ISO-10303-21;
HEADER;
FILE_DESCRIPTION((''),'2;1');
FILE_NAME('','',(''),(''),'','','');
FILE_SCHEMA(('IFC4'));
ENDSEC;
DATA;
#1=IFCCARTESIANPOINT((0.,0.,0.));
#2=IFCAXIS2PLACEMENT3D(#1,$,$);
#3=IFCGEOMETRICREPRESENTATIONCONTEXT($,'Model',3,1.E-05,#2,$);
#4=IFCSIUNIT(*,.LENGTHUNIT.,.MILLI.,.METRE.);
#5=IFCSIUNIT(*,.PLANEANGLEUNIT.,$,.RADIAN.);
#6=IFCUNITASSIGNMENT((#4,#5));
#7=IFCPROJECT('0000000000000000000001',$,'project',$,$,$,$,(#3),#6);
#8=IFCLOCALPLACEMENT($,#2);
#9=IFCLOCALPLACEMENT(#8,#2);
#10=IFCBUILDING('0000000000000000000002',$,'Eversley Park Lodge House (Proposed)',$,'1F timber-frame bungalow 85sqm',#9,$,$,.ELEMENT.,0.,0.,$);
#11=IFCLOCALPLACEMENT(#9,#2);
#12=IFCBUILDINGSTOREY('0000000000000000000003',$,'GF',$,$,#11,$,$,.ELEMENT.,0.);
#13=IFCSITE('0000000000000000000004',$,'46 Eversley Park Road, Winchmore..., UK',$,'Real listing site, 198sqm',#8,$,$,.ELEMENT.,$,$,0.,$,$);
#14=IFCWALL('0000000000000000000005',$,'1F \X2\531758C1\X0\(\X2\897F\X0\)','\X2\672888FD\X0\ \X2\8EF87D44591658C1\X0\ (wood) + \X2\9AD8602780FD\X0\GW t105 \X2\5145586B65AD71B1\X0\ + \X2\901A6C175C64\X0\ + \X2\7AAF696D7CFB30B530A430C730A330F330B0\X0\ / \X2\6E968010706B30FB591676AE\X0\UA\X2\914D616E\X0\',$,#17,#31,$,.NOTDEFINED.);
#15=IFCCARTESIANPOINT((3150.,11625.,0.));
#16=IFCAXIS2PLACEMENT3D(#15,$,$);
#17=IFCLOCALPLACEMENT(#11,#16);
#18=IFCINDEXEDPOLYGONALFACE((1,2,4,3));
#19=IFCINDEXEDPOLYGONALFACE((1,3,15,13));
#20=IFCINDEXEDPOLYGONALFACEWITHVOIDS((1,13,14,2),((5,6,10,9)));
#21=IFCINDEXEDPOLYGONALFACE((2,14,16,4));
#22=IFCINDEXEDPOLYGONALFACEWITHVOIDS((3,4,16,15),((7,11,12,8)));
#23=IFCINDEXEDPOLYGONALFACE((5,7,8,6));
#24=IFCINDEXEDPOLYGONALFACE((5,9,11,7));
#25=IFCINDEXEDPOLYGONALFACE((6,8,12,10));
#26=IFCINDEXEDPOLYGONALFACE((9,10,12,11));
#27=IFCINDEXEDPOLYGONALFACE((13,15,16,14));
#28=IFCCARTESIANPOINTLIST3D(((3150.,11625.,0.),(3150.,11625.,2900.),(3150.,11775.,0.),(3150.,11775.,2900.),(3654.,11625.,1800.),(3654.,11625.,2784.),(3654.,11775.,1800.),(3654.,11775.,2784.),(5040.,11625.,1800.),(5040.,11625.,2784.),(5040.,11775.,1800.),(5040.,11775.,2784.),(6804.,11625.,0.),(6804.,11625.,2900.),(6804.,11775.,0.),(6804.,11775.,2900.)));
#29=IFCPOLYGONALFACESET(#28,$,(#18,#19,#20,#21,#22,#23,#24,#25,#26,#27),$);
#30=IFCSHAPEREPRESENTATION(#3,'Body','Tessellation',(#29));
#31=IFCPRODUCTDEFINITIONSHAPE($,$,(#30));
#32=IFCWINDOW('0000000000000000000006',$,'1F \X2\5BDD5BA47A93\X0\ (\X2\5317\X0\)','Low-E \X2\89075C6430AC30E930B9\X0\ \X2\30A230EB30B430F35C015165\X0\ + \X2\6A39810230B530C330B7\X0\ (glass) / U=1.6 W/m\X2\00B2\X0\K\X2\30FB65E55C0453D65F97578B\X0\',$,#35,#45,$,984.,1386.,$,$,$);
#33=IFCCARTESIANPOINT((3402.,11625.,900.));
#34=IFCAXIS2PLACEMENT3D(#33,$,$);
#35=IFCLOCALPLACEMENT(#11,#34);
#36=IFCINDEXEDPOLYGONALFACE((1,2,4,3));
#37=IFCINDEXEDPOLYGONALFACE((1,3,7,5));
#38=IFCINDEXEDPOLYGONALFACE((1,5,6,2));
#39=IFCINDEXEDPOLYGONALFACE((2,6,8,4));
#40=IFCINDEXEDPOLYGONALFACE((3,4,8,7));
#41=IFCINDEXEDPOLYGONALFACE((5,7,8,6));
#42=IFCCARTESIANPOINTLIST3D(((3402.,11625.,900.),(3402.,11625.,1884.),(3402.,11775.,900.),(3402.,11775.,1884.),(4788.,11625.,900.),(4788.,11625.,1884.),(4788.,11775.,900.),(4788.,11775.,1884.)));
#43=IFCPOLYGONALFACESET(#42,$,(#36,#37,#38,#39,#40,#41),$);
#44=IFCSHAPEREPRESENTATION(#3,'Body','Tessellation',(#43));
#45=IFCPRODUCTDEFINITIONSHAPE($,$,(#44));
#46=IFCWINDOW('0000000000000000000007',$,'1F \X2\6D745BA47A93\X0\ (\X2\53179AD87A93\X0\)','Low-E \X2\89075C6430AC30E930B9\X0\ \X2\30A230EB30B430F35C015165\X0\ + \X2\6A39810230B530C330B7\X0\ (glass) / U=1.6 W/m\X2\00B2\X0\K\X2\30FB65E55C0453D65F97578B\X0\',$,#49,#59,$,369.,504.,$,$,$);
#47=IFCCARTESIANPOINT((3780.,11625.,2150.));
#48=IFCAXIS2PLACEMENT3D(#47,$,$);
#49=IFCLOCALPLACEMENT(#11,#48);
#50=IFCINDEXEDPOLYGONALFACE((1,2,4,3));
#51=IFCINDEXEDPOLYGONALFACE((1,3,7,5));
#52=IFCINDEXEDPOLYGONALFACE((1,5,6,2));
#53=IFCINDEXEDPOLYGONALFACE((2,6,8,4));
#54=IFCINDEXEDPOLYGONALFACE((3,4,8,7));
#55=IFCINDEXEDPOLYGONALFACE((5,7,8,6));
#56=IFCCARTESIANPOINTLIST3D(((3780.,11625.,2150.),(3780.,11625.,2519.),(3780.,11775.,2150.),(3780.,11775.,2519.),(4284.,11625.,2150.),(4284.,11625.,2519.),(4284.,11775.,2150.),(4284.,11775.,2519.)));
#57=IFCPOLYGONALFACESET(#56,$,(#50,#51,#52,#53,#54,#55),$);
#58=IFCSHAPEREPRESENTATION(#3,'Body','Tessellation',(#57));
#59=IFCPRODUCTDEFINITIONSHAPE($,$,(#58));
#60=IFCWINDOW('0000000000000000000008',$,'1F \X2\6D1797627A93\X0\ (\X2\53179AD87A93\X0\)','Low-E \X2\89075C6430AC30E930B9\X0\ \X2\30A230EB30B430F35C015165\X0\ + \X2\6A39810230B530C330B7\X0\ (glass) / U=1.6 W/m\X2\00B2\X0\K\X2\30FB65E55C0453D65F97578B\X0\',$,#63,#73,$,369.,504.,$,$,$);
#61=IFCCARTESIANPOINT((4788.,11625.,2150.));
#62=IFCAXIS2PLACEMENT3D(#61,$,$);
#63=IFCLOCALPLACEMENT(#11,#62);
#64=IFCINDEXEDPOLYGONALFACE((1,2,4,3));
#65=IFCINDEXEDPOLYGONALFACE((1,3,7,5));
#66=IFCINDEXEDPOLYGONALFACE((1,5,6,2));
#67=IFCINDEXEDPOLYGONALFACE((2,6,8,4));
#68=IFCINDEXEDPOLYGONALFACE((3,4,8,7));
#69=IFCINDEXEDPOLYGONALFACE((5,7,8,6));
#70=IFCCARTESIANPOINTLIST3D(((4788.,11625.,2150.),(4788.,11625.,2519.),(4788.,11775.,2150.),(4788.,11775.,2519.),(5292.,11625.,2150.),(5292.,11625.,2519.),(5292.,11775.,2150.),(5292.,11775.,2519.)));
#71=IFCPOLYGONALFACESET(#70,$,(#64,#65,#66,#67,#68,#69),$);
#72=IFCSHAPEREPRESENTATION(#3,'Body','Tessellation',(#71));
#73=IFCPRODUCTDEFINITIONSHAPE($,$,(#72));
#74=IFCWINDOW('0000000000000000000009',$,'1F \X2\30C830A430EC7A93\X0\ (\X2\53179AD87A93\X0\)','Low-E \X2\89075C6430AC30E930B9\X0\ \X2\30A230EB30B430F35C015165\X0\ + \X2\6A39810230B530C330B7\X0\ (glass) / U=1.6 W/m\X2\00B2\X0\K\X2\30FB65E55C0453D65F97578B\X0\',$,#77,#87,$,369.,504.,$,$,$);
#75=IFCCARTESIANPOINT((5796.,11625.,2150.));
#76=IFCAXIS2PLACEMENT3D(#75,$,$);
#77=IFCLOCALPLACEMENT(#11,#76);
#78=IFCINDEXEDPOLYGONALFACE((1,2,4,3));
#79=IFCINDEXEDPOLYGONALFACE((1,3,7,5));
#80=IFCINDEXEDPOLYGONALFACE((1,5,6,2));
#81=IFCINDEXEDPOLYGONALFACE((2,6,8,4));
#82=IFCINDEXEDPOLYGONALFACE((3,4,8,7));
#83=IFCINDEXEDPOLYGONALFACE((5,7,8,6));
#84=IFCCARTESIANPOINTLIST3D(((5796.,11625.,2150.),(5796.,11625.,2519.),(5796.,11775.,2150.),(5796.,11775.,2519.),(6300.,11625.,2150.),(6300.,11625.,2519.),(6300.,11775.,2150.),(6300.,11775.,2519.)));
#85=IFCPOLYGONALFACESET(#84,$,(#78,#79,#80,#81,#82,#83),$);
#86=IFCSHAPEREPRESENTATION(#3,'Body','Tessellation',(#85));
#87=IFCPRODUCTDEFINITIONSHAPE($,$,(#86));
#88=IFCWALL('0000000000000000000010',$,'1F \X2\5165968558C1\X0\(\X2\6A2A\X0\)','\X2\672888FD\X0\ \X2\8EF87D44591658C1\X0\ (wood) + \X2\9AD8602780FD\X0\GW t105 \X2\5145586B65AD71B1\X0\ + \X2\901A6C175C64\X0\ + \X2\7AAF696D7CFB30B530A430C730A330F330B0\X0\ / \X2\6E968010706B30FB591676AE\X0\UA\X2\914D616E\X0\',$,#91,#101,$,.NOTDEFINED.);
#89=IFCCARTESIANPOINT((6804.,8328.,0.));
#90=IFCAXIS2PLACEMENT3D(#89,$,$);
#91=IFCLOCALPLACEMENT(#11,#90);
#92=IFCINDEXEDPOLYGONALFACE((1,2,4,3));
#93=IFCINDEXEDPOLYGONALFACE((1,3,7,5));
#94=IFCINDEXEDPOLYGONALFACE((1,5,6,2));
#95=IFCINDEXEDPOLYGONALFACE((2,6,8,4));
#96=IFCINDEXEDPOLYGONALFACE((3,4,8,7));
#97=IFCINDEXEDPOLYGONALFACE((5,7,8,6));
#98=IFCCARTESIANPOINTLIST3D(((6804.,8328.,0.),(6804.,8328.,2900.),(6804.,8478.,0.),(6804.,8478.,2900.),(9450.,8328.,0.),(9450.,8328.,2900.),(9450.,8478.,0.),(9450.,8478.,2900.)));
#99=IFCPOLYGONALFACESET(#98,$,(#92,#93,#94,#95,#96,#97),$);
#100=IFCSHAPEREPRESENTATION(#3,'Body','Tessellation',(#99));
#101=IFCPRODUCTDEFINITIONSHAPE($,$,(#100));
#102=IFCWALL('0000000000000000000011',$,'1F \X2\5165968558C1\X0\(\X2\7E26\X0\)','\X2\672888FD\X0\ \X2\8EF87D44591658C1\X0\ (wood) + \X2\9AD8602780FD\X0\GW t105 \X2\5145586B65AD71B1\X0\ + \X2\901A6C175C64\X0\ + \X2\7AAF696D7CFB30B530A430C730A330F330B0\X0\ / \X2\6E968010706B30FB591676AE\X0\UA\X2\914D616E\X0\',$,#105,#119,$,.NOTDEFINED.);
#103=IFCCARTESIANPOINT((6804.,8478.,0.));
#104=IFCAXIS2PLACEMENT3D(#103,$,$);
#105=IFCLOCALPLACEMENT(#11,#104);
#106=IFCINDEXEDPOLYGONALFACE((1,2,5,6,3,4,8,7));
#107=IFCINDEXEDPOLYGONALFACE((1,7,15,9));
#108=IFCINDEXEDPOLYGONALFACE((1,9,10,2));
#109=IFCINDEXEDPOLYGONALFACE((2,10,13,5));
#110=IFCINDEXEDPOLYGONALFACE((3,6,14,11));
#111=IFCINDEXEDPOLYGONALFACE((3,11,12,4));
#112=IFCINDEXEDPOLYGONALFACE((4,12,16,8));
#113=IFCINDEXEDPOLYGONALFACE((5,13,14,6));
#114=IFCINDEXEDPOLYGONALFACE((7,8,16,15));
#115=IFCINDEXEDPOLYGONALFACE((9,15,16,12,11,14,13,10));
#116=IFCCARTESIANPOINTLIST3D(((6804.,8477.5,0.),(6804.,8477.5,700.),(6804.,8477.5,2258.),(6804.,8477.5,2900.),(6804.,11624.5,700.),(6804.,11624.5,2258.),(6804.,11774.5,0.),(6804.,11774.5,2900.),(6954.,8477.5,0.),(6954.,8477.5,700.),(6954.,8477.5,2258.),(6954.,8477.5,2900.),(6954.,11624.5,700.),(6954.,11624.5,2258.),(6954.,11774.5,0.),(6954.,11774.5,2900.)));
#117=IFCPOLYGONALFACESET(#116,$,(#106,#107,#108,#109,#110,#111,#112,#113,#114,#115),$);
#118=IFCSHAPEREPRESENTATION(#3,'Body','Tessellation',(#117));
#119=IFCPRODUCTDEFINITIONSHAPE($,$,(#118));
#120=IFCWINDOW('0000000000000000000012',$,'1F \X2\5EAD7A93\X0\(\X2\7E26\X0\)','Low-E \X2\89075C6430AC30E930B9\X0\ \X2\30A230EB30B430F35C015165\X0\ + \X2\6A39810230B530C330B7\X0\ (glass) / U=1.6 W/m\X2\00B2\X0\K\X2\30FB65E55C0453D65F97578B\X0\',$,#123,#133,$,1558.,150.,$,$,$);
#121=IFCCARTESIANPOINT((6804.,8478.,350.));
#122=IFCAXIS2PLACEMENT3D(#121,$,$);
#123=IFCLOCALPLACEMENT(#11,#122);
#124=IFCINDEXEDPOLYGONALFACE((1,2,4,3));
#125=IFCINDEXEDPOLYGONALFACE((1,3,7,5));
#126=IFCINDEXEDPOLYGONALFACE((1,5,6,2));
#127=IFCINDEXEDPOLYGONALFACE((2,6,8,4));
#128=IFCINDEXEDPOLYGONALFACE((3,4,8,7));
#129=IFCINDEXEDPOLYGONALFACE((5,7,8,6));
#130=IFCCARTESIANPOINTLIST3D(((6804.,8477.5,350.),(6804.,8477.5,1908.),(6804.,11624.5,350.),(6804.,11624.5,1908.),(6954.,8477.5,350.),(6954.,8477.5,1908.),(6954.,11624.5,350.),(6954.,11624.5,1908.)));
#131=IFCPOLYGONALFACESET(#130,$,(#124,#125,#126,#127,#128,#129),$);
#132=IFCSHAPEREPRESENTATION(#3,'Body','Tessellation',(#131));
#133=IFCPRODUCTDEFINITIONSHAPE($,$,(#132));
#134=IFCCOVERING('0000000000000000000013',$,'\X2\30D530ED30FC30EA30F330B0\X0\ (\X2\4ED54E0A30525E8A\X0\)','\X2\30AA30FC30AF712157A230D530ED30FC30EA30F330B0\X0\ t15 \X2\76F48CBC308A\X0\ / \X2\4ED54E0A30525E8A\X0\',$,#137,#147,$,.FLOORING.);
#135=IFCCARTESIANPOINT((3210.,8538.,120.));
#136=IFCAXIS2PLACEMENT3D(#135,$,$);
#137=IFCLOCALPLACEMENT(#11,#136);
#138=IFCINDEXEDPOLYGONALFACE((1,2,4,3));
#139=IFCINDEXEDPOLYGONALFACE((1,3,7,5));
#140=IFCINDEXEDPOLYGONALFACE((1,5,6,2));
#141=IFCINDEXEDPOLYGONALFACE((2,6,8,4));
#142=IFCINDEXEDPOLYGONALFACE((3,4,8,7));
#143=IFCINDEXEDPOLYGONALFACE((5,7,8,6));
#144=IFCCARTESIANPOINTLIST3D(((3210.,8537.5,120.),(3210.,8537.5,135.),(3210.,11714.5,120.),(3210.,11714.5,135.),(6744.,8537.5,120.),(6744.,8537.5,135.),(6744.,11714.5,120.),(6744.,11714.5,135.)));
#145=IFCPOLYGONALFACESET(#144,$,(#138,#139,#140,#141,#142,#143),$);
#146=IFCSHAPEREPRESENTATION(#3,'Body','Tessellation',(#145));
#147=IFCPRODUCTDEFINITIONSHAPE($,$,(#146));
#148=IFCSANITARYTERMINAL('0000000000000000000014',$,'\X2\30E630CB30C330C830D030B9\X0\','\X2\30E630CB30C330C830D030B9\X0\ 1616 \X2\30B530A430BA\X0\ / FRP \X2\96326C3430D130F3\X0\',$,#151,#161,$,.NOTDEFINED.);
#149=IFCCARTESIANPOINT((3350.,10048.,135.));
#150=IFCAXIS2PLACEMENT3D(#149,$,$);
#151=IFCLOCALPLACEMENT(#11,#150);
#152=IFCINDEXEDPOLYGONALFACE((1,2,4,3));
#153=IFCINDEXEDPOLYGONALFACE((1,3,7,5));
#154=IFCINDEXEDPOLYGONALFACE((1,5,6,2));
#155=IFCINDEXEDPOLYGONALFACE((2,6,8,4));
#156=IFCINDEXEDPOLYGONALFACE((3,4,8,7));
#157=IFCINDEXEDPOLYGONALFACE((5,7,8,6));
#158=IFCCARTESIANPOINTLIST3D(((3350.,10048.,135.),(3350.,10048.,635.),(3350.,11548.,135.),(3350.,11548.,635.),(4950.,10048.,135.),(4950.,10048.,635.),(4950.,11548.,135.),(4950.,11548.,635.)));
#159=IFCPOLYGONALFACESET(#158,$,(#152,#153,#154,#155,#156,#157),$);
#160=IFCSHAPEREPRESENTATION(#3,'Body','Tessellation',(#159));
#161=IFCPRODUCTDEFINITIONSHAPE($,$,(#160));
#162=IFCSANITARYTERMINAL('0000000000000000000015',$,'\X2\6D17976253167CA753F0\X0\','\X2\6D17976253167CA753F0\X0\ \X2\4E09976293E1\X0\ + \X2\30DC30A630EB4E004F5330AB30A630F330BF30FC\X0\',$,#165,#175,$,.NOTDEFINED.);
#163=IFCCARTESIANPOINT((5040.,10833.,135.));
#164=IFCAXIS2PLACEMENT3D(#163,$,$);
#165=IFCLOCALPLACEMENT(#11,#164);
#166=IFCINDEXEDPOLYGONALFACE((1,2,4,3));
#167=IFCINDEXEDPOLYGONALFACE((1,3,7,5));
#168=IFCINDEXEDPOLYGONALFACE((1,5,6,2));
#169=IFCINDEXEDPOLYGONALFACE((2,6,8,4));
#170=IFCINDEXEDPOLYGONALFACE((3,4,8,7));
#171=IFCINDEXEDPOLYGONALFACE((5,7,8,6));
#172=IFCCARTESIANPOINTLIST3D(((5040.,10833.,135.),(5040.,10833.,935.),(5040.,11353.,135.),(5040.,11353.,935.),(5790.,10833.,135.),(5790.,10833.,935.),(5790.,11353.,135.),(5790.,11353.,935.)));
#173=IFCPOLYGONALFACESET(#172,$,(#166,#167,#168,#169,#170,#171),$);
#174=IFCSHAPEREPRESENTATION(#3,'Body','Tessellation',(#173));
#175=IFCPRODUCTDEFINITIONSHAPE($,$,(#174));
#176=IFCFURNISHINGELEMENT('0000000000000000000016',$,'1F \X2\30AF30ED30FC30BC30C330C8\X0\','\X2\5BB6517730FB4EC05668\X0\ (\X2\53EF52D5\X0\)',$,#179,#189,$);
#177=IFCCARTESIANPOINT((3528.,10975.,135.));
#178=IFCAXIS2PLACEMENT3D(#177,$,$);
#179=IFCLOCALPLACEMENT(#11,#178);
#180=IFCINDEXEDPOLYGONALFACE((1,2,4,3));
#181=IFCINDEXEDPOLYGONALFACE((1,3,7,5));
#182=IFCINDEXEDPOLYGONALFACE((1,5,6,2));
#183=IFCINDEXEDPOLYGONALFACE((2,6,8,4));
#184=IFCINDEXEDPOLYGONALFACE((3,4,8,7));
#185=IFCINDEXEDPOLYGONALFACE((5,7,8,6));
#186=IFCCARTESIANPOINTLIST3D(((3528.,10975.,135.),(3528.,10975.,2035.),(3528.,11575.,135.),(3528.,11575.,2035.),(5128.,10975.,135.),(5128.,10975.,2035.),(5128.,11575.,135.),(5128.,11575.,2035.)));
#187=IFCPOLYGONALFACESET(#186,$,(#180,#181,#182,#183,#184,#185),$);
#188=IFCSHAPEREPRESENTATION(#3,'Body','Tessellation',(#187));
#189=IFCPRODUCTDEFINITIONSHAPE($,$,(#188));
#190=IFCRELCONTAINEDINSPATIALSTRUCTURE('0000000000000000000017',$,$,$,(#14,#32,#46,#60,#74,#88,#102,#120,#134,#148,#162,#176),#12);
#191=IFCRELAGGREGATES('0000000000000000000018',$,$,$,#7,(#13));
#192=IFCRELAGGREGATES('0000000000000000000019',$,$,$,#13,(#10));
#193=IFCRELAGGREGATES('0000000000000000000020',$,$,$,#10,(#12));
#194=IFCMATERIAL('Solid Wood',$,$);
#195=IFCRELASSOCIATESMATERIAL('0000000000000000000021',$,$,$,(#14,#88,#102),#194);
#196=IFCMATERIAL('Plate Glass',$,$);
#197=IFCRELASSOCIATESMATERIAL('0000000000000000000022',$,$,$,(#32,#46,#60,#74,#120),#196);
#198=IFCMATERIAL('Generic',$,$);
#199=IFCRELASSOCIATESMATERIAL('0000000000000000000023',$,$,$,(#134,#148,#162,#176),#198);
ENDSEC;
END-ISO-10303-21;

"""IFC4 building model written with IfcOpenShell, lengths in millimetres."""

from ifc_helpers import new_model, si_unit, frame, frame_2d, origin, place, context, project, spatial, rectangle, extrude, material, element, fill, save


model = new_model("IFC4")

# Units and contexts
model_context = context("Model", 3, precision=1e-05, world=origin())
ifc_project = project(units=[si_unit("LENGTHUNIT", "METRE", prefix="MILLI"), si_unit("PLANEANGLEUNIT", "RADIAN")], contexts=[model_context])

# Site, building, storey
site_placement = place(None, origin())
site = spatial("IfcSite", under=ifc_project, at=site_placement, Name="46 Eversley Park Road, Winchmore..., UK", ObjectType="Real listing site, 198sqm", CompositionType="ELEMENT", RefElevation=0.0)
building_placement = place(site_placement, origin())
building = spatial("IfcBuilding", under=site, at=building_placement, Name="Eversley Park Lodge House (Proposed)", ObjectType="1F timber-frame bungalow 85sqm", CompositionType="ELEMENT", ElevationOfRefHeight=0.0, ElevationOfTerrain=0.0)
storey_placement = place(building_placement, origin())
storey = spatial("IfcBuildingStorey", under=building, at=storey_placement, Name="GF", CompositionType="ELEMENT", Elevation=0.0)

# Shared definitions
ifc_material_1 = material(Name="Solid Wood")

# Wall, openings, windows
wall_1_placement = place(storey_placement, frame((3150.0, 11625.0, 0.0)))
wall_1 = element("IfcWall", 1, at=wall_1_placement, inside=storey, material=ifc_material_1, Name="1F 北壁(西)", Description="木製 軸組外壁 (wood) + 高性能GW t105 充填断熱 + 通気層 + 窯業系サイディング / 準耐火・外皮UA配慮", PredefinedType="NOTDEFINED", context=model_context, shape_type="SweptSolid", body=[
    extrude(rectangle(XDim=3654.0, YDim=150.0, at=frame_2d((1827.0, 75.0))), frame((3150.0, 11625.0, 0.0)), (0.0, 0.0, 1.0), 2900.0),
])
opening_1_placement = place(storey_placement, frame((3402.0, 11625.0, 900.0)))
opening_1 = element("IfcOpeningElement", 2, at=opening_1_placement, cuts=wall_1, PredefinedType="NOTDEFINED", context=model_context, shape_type="SweptSolid", body=[
    extrude(rectangle(XDim=1386.0, YDim=150.0, at=frame_2d((693.0, 75.0))), frame((3402.0, 11625.0, 900.0)), (0.0, 0.0, 1.0), 984.0),
])
opening_2_placement = place(storey_placement, frame((3780.0, 11625.0, 2150.0)))
opening_2 = element("IfcOpeningElement", 3, at=opening_2_placement, cuts=wall_1, PredefinedType="NOTDEFINED", context=model_context, shape_type="SweptSolid", body=[
    extrude(rectangle(XDim=504.0, YDim=150.0, at=frame_2d((252.0, 75.0))), frame((3780.0, 11625.0, 2150.0)), (0.0, 0.0, 1.0), 369.0),
])
opening_3_placement = place(storey_placement, frame((4788.0, 11625.0, 2150.0)))
opening_3 = element("IfcOpeningElement", 4, at=opening_3_placement, cuts=wall_1, PredefinedType="NOTDEFINED", context=model_context, shape_type="SweptSolid", body=[
    extrude(rectangle(XDim=504.0, YDim=150.0, at=frame_2d((252.0, 75.0))), frame((4788.0, 11625.0, 2150.0)), (0.0, 0.0, 1.0), 369.0),
])
opening_4_placement = place(storey_placement, frame((5796.0, 11625.0, 2150.0)))
opening_4 = element("IfcOpeningElement", 5, at=opening_4_placement, cuts=wall_1, PredefinedType="NOTDEFINED", context=model_context, shape_type="SweptSolid", body=[
    extrude(rectangle(XDim=504.0, YDim=150.0, at=frame_2d((252.0, 75.0))), frame((5796.0, 11625.0, 2150.0)), (0.0, 0.0, 1.0), 369.0),
])
ifc_material_2 = material(Name="Plate Glass")
window_1_placement = place(storey_placement, frame((3402.0, 11625.0, 900.0)))
window_1 = element("IfcWindow", 6, at=window_1_placement, inside=storey, material=ifc_material_2, Name="1F 寝室窓 (北)", Description="Low-E 複層ガラス アルゴン封入 + 樹脂サッシ (glass) / U=1.6 W/m²K・日射取得型", OverallHeight=984.0, OverallWidth=1386.0, context=model_context, shape_type="SweptSolid", body=[
    extrude(rectangle(XDim=1386.0, YDim=150.0, at=frame_2d((693.0, 75.0))), frame((3402.0, 11625.0, 900.0)), (0.0, 0.0, 1.0), 984.0),
])
fill(opening_1, window_1)
window_2_placement = place(storey_placement, frame((3780.0, 11625.0, 2150.0)))
window_2 = element("IfcWindow", 7, at=window_2_placement, inside=storey, material=ifc_material_2, Name="1F 浴室窓 (北高窓)", Description="Low-E 複層ガラス アルゴン封入 + 樹脂サッシ (glass) / U=1.6 W/m²K・日射取得型", OverallHeight=369.0, OverallWidth=504.0, context=model_context, shape_type="SweptSolid", body=[
    extrude(rectangle(XDim=504.0, YDim=150.0, at=frame_2d((252.0, 75.0))), frame((3780.0, 11625.0, 2150.0)), (0.0, 0.0, 1.0), 369.0),
])
fill(opening_2, window_2)
window_3_placement = place(storey_placement, frame((4788.0, 11625.0, 2150.0)))
window_3 = element("IfcWindow", 8, at=window_3_placement, inside=storey, material=ifc_material_2, Name="1F 洗面窓 (北高窓)", Description="Low-E 複層ガラス アルゴン封入 + 樹脂サッシ (glass) / U=1.6 W/m²K・日射取得型", OverallHeight=369.0, OverallWidth=504.0, context=model_context, shape_type="SweptSolid", body=[
    extrude(rectangle(XDim=504.0, YDim=150.0, at=frame_2d((252.0, 75.0))), frame((4788.0, 11625.0, 2150.0)), (0.0, 0.0, 1.0), 369.0),
])
fill(opening_3, window_3)
window_4_placement = place(storey_placement, frame((5796.0, 11625.0, 2150.0)))
window_4 = element("IfcWindow", 9, at=window_4_placement, inside=storey, material=ifc_material_2, Name="1F トイレ窓 (北高窓)", Description="Low-E 複層ガラス アルゴン封入 + 樹脂サッシ (glass) / U=1.6 W/m²K・日射取得型", OverallHeight=369.0, OverallWidth=504.0, context=model_context, shape_type="SweptSolid", body=[
    extrude(rectangle(XDim=504.0, YDim=150.0, at=frame_2d((252.0, 75.0))), frame((5796.0, 11625.0, 2150.0)), (0.0, 0.0, 1.0), 369.0),
])
fill(opening_4, window_4)

# Wall
wall_2_placement = place(storey_placement, frame((6804.0, 8328.0, 0.0)))
element("IfcWall", 10, at=wall_2_placement, inside=storey, material=ifc_material_1, Name="1F 入隅壁(横)", Description="木製 軸組外壁 (wood) + 高性能GW t105 充填断熱 + 通気層 + 窯業系サイディング / 準耐火・外皮UA配慮", PredefinedType="NOTDEFINED", context=model_context, shape_type="SweptSolid", body=[
    extrude(rectangle(XDim=2646.0, YDim=150.0, at=frame_2d((1323.0, 75.0))), frame((6804.0, 8328.0, 0.0)), (0.0, 0.0, 1.0), 2900.0),
])

# Wall, opening, window
wall_3_placement = place(storey_placement, frame((6804.0, 8478.0, 0.0)))
wall_3 = element("IfcWall", 11, at=wall_3_placement, inside=storey, material=ifc_material_1, Name="1F 入隅壁(縦)", Description="木製 軸組外壁 (wood) + 高性能GW t105 充填断熱 + 通気層 + 窯業系サイディング / 準耐火・外皮UA配慮", PredefinedType="NOTDEFINED", context=model_context, shape_type="SweptSolid", body=[
    extrude(rectangle(XDim=150.0, YDim=3297.0, at=frame_2d((75.0, 1648.0))), frame((6804.0, 8478.0, 0.0)), (0.0, 0.0, 1.0), 2900.0),
])
opening_5_placement = place(storey_placement, frame((6804.0, 8478.0, 350.0)))
opening_5 = element("IfcOpeningElement", 12, at=opening_5_placement, cuts=wall_3, PredefinedType="NOTDEFINED", context=model_context, shape_type="SweptSolid", body=[
    extrude(rectangle(XDim=150.0, YDim=3147.0, at=frame_2d((75.0, 1573.0))), frame((6804.0, 8478.0, 350.0)), (0.0, 0.0, 1.0), 1558.0),
])
window_5_placement = place(storey_placement, frame((6804.0, 8478.0, 350.0)))
window_5 = element("IfcWindow", 13, at=window_5_placement, inside=storey, material=ifc_material_2, Name="1F 庭窓(縦)", Description="Low-E 複層ガラス アルゴン封入 + 樹脂サッシ (glass) / U=1.6 W/m²K・日射取得型", OverallHeight=1558.0, OverallWidth=150.0, context=model_context, shape_type="SweptSolid", body=[
    extrude(rectangle(XDim=150.0, YDim=3147.0, at=frame_2d((75.0, 1573.0))), frame((6804.0, 8478.0, 350.0)), (0.0, 0.0, 1.0), 1558.0),
])
fill(opening_5, window_5)

# Covering
ifc_material_3 = material(Name="Generic")
covering_placement = place(storey_placement, frame((3210.0, 8538.0, 120.0)))
element("IfcCovering", 14, at=covering_placement, inside=storey, material=ifc_material_3, Name="フローリング (仕上げ床)", Description="オーク無垢フローリング t15 直貼り / 仕上げ床", PredefinedType="FLOORING", context=model_context, shape_type="SweptSolid", body=[
    extrude(rectangle(XDim=3534.0, YDim=3177.0, at=frame_2d((1767.0, 1588.0))), frame((3210.0, 8538.0, 120.0)), (0.0, 0.0, 1.0), 15.0),
])

# Sanitary terminals
sanitary_terminal_1_placement = place(storey_placement, frame((3350.0, 10048.0, 135.0)))
element("IfcSanitaryTerminal", 15, at=sanitary_terminal_1_placement, inside=storey, material=ifc_material_3, Name="ユニットバス", Description="ユニットバス 1616 サイズ / FRP 防水パン", PredefinedType="NOTDEFINED", context=model_context, shape_type="SweptSolid", body=[
    extrude(rectangle(XDim=1600.0, YDim=1500.0, at=frame_2d((800.0, 750.0))), frame((3350.0, 10048.0, 135.0)), (0.0, 0.0, 1.0), 500.0),
])
sanitary_terminal_2_placement = place(storey_placement, frame((5040.0, 10833.0, 135.0)))
element("IfcSanitaryTerminal", 16, at=sanitary_terminal_2_placement, inside=storey, material=ifc_material_3, Name="洗面化粧台", Description="洗面化粧台 三面鏡 + ボウル一体カウンター", PredefinedType="NOTDEFINED", context=model_context, shape_type="SweptSolid", body=[
    extrude(rectangle(XDim=750.0, YDim=520.0, at=frame_2d((375.0, 260.0))), frame((5040.0, 10833.0, 135.0)), (0.0, 0.0, 1.0), 800.0),
])

# Furnishing element
furnishing_1_placement = place(storey_placement, frame((3528.0, 10975.0, 135.0)))
element("IfcFurnishingElement", 17, at=furnishing_1_placement, inside=storey, material=ifc_material_3, Name="1F クローゼット", Description="家具・什器 (可動)", context=model_context, shape_type="SweptSolid", body=[
    extrude(rectangle(XDim=1600.0, YDim=600.0, at=frame_2d((800.0, 300.0))), frame((3528.0, 10975.0, 135.0)), (0.0, 0.0, 1.0), 1900.0),
])

save(model, "model.ifc")
